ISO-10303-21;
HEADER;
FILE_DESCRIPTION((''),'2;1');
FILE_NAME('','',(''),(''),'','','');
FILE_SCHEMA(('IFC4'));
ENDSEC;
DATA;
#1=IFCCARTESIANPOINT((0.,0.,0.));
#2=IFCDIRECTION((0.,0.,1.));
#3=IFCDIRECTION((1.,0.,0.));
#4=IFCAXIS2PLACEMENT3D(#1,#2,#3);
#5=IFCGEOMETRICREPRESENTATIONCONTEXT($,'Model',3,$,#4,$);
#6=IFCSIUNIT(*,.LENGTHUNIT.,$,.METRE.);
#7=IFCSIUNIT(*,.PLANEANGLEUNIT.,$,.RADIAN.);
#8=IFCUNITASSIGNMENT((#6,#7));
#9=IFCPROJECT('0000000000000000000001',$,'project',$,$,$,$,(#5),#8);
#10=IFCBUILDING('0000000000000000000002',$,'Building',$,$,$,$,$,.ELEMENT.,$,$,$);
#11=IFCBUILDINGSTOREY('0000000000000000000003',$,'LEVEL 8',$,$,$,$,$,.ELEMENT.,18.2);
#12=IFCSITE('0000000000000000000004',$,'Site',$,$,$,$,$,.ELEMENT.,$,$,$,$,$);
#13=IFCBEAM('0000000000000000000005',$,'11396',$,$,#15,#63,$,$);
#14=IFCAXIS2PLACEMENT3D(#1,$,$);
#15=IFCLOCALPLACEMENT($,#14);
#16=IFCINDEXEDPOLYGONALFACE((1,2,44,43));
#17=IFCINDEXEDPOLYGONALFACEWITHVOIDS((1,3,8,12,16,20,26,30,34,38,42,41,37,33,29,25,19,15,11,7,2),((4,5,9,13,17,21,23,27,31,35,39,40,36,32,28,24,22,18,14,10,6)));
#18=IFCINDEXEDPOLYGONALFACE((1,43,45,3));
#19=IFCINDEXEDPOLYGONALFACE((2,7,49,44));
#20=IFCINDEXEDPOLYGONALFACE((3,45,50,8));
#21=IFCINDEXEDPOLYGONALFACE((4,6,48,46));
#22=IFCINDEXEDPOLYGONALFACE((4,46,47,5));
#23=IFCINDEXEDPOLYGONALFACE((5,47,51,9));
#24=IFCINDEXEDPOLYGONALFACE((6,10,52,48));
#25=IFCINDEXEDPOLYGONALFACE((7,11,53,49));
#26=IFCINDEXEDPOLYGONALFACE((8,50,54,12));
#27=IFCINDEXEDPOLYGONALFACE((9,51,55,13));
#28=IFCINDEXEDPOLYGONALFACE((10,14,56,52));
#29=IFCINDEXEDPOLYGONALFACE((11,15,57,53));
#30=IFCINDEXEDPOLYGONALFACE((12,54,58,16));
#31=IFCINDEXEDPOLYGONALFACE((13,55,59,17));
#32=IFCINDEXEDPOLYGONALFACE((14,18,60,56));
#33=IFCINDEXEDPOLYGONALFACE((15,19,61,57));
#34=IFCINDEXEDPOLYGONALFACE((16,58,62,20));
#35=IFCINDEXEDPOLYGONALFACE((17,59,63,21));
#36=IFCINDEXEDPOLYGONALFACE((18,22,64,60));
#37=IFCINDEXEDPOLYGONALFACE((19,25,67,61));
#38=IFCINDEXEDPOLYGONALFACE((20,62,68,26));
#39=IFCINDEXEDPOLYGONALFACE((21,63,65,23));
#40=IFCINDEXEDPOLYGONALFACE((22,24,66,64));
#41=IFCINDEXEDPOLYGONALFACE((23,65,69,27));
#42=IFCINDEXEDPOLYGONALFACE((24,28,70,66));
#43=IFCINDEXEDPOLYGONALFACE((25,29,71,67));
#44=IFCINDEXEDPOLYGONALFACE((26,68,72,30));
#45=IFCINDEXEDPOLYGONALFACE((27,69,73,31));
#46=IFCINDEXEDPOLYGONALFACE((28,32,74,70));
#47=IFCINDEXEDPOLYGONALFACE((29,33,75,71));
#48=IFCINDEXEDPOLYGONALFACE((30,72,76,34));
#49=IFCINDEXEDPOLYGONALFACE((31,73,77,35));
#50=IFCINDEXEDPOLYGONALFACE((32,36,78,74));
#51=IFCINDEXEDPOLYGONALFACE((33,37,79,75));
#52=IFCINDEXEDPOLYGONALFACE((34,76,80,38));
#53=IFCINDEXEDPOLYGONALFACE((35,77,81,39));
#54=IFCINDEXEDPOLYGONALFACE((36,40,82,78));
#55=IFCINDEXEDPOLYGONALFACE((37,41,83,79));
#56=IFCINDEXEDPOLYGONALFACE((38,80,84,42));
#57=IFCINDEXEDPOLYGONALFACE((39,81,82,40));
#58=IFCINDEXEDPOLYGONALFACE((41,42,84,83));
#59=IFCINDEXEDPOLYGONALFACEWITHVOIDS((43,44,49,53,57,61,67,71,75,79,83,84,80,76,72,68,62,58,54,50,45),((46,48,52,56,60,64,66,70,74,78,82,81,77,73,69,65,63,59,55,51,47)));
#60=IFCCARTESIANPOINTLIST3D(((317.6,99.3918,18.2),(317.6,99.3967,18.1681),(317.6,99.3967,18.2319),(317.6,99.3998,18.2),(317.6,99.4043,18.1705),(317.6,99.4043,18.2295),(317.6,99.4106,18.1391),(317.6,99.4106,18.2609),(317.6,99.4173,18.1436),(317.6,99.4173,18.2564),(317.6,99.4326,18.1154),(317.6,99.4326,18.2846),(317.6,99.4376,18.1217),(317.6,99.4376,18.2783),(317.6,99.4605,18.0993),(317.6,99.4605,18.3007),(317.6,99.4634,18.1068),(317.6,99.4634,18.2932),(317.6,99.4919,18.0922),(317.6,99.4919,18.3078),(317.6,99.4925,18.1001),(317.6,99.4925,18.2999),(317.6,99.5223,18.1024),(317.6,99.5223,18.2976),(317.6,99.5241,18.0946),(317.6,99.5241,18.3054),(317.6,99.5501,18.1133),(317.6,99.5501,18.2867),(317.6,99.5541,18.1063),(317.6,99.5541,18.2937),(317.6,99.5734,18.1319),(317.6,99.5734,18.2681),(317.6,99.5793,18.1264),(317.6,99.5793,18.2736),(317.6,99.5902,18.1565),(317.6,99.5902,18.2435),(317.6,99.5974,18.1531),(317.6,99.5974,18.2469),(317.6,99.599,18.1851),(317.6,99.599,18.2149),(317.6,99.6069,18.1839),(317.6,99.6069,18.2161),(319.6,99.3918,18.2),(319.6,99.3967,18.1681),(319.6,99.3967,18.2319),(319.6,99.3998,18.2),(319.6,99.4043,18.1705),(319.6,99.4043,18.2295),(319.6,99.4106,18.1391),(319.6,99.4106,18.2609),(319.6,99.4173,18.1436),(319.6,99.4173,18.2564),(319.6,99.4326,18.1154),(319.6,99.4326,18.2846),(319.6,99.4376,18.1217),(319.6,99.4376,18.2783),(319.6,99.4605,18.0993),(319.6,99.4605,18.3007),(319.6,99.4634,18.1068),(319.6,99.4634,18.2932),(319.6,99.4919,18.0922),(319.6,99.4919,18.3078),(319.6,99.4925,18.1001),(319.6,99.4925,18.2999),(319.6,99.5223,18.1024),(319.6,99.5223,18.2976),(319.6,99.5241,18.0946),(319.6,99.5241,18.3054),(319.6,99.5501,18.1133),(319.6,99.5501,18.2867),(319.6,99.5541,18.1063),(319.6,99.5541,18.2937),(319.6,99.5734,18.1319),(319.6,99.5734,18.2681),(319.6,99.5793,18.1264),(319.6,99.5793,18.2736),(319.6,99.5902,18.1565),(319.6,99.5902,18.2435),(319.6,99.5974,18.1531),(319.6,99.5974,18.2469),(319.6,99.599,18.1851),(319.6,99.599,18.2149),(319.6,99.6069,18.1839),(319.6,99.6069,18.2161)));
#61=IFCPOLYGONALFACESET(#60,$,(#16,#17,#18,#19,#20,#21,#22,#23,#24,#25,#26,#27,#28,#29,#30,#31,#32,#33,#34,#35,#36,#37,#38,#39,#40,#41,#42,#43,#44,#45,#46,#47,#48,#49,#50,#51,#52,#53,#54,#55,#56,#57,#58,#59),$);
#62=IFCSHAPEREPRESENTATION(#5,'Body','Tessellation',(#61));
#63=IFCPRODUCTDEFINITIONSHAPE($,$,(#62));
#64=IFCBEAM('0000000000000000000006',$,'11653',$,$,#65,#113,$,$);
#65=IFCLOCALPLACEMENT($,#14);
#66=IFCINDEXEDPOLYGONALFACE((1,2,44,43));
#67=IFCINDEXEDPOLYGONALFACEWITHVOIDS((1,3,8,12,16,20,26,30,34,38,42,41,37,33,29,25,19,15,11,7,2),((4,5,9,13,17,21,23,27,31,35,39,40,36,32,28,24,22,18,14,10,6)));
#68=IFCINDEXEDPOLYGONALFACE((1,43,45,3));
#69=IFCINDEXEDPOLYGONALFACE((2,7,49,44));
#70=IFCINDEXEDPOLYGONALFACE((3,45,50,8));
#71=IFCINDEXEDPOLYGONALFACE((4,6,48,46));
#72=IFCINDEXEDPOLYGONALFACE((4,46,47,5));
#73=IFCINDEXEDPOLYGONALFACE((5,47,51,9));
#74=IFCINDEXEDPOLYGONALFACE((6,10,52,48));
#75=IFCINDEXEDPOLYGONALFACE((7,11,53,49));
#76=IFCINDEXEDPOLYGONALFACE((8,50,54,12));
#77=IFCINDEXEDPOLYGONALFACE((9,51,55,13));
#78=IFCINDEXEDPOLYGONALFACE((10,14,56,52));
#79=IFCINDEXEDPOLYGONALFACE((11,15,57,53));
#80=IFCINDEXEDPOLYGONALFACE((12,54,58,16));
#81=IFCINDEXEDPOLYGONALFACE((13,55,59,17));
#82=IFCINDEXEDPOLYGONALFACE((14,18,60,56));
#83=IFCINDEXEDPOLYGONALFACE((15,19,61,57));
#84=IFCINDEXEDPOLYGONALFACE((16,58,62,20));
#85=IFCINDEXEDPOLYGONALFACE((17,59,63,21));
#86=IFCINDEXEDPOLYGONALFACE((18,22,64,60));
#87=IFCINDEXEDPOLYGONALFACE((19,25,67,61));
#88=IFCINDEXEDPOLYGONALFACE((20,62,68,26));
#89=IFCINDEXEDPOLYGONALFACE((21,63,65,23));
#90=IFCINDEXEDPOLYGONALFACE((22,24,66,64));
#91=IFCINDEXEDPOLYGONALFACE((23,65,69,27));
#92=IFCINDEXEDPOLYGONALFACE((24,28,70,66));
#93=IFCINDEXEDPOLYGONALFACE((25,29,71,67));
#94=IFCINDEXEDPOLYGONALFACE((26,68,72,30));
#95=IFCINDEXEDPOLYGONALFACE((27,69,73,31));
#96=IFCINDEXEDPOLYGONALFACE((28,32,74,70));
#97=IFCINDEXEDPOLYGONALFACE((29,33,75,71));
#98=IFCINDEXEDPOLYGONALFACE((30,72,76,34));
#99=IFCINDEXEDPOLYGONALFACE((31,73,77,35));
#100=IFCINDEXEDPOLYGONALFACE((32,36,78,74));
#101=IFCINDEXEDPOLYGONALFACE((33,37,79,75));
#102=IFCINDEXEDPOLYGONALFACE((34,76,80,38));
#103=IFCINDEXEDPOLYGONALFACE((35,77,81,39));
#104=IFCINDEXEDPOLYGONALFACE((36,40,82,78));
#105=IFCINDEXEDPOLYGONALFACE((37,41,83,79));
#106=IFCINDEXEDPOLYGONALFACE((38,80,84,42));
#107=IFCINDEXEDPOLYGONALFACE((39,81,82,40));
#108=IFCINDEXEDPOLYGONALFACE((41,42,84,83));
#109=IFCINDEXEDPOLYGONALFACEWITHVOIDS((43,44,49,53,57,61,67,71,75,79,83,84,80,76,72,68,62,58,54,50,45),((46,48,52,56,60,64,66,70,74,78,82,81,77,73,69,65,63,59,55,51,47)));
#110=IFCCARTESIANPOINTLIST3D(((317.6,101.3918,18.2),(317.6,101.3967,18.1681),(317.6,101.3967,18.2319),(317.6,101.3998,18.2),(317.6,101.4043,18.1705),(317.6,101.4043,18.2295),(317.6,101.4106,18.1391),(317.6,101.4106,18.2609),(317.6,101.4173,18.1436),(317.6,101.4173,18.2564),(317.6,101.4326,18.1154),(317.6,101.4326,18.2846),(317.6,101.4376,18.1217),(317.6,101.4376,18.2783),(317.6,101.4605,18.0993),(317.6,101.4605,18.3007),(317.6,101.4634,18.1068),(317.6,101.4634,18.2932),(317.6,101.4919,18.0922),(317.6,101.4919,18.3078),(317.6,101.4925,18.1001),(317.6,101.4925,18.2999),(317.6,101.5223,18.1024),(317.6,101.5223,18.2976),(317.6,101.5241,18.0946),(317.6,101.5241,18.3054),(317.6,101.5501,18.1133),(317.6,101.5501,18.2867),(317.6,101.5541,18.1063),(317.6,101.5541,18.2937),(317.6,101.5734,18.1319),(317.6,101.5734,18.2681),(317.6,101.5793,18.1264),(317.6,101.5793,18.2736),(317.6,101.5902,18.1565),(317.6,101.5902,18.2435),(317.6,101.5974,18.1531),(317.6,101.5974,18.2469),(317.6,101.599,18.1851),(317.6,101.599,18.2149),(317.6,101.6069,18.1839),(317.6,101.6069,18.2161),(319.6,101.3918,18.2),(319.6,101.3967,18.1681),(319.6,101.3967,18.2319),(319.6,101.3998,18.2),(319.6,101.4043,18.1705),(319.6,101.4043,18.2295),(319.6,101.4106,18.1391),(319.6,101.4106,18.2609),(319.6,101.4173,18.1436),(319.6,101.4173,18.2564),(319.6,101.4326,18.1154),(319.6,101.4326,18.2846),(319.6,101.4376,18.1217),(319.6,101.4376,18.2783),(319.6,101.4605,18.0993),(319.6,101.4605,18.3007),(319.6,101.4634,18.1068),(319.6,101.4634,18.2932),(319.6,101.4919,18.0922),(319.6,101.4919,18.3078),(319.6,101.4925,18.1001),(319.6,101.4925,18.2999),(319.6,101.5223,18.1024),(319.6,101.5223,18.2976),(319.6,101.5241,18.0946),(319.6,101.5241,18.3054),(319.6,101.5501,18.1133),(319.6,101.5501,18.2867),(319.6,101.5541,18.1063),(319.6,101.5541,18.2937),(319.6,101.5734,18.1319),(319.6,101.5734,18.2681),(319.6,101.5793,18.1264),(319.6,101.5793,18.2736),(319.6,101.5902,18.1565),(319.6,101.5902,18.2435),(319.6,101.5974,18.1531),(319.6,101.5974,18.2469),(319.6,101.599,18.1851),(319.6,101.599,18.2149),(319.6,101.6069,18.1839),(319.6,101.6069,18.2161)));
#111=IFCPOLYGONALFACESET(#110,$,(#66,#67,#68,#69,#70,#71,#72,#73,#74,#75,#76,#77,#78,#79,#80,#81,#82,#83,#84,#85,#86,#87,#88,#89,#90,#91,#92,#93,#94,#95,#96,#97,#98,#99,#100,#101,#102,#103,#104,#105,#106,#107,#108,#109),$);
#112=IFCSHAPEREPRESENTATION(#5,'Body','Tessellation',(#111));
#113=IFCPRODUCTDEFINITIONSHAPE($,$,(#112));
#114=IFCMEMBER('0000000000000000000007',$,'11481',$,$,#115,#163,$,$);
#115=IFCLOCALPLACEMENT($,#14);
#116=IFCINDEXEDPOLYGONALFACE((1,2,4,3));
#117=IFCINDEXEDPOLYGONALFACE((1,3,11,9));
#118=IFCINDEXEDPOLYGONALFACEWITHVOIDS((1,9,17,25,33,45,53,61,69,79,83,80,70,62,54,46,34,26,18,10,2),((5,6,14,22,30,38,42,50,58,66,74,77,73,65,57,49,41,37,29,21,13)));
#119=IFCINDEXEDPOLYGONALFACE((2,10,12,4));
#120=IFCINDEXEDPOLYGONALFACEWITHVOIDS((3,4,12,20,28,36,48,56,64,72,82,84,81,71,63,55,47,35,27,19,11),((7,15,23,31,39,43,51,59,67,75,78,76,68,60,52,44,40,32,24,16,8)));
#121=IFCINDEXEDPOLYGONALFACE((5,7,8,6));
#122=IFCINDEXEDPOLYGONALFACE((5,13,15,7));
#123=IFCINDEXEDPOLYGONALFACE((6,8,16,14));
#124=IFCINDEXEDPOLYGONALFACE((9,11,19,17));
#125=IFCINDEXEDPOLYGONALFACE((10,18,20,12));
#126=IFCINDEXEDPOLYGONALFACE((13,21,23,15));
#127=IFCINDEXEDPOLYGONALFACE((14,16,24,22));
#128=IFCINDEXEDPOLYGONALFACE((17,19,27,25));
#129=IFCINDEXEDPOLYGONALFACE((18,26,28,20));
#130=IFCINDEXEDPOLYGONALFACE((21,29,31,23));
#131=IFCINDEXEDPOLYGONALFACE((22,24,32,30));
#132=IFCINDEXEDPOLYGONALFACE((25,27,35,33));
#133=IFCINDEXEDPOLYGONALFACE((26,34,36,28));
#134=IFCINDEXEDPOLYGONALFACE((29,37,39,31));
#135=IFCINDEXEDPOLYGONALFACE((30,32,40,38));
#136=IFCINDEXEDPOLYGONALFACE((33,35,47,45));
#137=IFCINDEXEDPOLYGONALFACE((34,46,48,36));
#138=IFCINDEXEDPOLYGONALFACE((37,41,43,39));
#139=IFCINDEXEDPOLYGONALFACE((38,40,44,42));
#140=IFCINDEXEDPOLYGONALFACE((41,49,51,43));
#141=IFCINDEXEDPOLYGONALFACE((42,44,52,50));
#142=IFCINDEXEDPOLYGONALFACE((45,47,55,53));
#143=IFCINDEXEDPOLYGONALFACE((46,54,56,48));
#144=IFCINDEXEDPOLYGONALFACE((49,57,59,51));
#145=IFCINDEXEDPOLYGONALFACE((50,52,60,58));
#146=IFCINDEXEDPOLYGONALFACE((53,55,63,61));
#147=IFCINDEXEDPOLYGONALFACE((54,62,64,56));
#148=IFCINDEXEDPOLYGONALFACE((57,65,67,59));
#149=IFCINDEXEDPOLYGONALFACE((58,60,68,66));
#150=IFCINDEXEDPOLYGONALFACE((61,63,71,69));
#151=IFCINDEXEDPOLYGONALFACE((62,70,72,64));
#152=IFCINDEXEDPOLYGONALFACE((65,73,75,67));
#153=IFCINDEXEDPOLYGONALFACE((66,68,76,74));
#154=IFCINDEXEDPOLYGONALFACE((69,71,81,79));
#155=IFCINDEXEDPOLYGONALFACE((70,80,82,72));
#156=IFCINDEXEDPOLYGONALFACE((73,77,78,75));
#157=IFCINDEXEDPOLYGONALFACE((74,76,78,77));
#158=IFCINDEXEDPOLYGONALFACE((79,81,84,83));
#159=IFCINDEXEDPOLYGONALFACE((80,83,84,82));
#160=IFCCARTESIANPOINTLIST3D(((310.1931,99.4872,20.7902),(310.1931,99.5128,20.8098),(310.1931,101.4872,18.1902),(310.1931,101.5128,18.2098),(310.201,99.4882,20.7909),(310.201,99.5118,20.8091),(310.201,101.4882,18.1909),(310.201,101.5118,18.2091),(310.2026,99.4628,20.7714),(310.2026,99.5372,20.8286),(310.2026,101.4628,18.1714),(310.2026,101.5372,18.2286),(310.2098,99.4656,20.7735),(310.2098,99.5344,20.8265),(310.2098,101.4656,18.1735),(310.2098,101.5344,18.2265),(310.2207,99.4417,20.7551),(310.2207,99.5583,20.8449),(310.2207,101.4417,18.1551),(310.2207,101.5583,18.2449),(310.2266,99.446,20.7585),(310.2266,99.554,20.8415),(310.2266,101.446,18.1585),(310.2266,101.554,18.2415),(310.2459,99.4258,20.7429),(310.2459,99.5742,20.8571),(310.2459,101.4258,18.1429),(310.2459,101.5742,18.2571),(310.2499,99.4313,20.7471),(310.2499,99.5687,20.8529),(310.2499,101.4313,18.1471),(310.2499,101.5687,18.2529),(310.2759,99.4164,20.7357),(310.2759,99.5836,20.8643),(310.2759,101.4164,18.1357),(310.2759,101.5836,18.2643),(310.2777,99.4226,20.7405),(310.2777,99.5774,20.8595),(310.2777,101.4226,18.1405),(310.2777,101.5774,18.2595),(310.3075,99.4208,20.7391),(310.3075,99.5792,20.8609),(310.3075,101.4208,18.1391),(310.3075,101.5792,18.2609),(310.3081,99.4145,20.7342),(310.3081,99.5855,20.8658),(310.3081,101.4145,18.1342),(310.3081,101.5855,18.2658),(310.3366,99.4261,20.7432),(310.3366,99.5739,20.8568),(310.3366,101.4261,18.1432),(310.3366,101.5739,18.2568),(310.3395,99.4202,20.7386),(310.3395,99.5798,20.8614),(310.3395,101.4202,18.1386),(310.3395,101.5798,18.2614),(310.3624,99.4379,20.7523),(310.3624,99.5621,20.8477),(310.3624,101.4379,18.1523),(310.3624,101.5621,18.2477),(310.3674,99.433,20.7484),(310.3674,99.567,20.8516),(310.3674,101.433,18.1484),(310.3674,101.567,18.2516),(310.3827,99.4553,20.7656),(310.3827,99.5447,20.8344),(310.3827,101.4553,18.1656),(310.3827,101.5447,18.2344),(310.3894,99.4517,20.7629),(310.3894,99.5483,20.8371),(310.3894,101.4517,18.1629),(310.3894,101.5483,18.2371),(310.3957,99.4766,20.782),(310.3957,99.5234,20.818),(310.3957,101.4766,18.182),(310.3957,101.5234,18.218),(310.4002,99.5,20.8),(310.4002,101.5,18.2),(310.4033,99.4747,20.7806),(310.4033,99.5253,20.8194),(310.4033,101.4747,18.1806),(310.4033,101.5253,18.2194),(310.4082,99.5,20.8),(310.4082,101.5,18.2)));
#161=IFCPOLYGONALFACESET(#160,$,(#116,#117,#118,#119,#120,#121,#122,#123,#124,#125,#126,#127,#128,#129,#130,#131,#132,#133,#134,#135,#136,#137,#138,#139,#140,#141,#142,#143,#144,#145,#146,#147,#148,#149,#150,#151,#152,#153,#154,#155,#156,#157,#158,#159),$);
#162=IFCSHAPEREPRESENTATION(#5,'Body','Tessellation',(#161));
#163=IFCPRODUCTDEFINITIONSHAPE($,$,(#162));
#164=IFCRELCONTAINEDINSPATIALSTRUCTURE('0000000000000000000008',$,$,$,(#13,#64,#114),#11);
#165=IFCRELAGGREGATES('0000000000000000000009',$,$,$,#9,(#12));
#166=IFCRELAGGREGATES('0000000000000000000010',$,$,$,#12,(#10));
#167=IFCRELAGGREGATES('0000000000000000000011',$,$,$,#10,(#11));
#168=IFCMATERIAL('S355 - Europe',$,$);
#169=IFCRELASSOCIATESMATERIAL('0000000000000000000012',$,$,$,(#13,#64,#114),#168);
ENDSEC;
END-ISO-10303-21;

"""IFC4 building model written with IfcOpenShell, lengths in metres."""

from ifc_helpers import new_model, si_unit, frame, origin_with_axes, origin_2d_with_axis, place, context, project, spatial, hollow_circle, extrude, material, material_profile, profile_set, profile_usage, element, save


model = new_model("IFC4")

# Units and contexts
model_context = context("Model", 3, world=origin_with_axes())
ifc_project = project(units=[si_unit("LENGTHUNIT", "METRE"), si_unit("PLANEANGLEUNIT", "RADIAN")], contexts=[model_context])

# Site, building, storey
site = spatial("IfcSite", under=ifc_project, Name="Site", CompositionType="ELEMENT")
building = spatial("IfcBuilding", under=site, Name="Building", CompositionType="ELEMENT")
storey = spatial("IfcBuildingStorey", under=building, Name="LEVEL 8", CompositionType="ELEMENT", Elevation=18.2)

# Shared definitions
ifc_material = material(Name="S355 - Europe")

# Beams
ifc_material_profile_1 = material_profile(ifc_material, hollow_circle(Radius=0.1081, WallThickness=0.008, at=origin_2d_with_axis()))
ifc_profile_set_1 = profile_set([ifc_material_profile_1])
ifc_profile_usage_1 = profile_usage(ifc_profile_set_1, cardinal=10)
beam_1_placement = place(None, frame((319.6, 99.5, 18.2), z_axis=(-1.0, 0.0, 0.0), x_axis=(0.0, -1.0, 0.0)))
element("IfcBeam", 1, at=beam_1_placement, inside=storey, material=ifc_profile_usage_1, Name="11396", context=model_context, shape_type="SweptSolid", body=[
    extrude(hollow_circle(Radius=0.1081, WallThickness=0.008, at=origin_2d_with_axis()), origin_with_axes(), (0.0, 0.0, 1.0), 2.0),
])
ifc_material_profile_2 = material_profile(ifc_material, hollow_circle(Radius=0.1081, WallThickness=0.008, at=origin_2d_with_axis()))
ifc_profile_set_2 = profile_set([ifc_material_profile_2])
ifc_profile_usage_2 = profile_usage(ifc_profile_set_2, cardinal=10)
beam_2_placement = place(None, frame((319.6, 101.5, 18.2), z_axis=(-1.0, 0.0, 0.0), x_axis=(0.0, -1.0, 0.0)))
element("IfcBeam", 2, at=beam_2_placement, inside=storey, material=ifc_profile_usage_2, Name="11653", context=model_context, shape_type="SweptSolid", body=[
    extrude(hollow_circle(Radius=0.1081, WallThickness=0.008, at=origin_2d_with_axis()), origin_with_axes(), (0.0, 0.0, 1.0), 2.0),
])

# Member
ifc_material_profile_3 = material_profile(ifc_material, hollow_circle(Radius=0.1081, WallThickness=0.008, at=origin_2d_with_axis()))
ifc_profile_set_3 = profile_set([ifc_material_profile_3])
ifc_profile_usage_3 = profile_usage(ifc_profile_set_3, cardinal=10)
member_1_placement = place(None, frame((310.3, 101.5, 18.2), z_axis=(0.0, -0.609711, 0.792624), x_axis=(1.0, 0.0, 0.0)))
element("IfcMember", 3, at=member_1_placement, inside=storey, material=ifc_profile_usage_3, Name="11481", context=model_context, shape_type="SweptSolid", body=[
    extrude(hollow_circle(Radius=0.1081, WallThickness=0.008, at=origin_2d_with_axis()), origin_with_axes(), (0.0, 0.0, 1.0), 3.2802),
])

save(model, "model.ifc")
